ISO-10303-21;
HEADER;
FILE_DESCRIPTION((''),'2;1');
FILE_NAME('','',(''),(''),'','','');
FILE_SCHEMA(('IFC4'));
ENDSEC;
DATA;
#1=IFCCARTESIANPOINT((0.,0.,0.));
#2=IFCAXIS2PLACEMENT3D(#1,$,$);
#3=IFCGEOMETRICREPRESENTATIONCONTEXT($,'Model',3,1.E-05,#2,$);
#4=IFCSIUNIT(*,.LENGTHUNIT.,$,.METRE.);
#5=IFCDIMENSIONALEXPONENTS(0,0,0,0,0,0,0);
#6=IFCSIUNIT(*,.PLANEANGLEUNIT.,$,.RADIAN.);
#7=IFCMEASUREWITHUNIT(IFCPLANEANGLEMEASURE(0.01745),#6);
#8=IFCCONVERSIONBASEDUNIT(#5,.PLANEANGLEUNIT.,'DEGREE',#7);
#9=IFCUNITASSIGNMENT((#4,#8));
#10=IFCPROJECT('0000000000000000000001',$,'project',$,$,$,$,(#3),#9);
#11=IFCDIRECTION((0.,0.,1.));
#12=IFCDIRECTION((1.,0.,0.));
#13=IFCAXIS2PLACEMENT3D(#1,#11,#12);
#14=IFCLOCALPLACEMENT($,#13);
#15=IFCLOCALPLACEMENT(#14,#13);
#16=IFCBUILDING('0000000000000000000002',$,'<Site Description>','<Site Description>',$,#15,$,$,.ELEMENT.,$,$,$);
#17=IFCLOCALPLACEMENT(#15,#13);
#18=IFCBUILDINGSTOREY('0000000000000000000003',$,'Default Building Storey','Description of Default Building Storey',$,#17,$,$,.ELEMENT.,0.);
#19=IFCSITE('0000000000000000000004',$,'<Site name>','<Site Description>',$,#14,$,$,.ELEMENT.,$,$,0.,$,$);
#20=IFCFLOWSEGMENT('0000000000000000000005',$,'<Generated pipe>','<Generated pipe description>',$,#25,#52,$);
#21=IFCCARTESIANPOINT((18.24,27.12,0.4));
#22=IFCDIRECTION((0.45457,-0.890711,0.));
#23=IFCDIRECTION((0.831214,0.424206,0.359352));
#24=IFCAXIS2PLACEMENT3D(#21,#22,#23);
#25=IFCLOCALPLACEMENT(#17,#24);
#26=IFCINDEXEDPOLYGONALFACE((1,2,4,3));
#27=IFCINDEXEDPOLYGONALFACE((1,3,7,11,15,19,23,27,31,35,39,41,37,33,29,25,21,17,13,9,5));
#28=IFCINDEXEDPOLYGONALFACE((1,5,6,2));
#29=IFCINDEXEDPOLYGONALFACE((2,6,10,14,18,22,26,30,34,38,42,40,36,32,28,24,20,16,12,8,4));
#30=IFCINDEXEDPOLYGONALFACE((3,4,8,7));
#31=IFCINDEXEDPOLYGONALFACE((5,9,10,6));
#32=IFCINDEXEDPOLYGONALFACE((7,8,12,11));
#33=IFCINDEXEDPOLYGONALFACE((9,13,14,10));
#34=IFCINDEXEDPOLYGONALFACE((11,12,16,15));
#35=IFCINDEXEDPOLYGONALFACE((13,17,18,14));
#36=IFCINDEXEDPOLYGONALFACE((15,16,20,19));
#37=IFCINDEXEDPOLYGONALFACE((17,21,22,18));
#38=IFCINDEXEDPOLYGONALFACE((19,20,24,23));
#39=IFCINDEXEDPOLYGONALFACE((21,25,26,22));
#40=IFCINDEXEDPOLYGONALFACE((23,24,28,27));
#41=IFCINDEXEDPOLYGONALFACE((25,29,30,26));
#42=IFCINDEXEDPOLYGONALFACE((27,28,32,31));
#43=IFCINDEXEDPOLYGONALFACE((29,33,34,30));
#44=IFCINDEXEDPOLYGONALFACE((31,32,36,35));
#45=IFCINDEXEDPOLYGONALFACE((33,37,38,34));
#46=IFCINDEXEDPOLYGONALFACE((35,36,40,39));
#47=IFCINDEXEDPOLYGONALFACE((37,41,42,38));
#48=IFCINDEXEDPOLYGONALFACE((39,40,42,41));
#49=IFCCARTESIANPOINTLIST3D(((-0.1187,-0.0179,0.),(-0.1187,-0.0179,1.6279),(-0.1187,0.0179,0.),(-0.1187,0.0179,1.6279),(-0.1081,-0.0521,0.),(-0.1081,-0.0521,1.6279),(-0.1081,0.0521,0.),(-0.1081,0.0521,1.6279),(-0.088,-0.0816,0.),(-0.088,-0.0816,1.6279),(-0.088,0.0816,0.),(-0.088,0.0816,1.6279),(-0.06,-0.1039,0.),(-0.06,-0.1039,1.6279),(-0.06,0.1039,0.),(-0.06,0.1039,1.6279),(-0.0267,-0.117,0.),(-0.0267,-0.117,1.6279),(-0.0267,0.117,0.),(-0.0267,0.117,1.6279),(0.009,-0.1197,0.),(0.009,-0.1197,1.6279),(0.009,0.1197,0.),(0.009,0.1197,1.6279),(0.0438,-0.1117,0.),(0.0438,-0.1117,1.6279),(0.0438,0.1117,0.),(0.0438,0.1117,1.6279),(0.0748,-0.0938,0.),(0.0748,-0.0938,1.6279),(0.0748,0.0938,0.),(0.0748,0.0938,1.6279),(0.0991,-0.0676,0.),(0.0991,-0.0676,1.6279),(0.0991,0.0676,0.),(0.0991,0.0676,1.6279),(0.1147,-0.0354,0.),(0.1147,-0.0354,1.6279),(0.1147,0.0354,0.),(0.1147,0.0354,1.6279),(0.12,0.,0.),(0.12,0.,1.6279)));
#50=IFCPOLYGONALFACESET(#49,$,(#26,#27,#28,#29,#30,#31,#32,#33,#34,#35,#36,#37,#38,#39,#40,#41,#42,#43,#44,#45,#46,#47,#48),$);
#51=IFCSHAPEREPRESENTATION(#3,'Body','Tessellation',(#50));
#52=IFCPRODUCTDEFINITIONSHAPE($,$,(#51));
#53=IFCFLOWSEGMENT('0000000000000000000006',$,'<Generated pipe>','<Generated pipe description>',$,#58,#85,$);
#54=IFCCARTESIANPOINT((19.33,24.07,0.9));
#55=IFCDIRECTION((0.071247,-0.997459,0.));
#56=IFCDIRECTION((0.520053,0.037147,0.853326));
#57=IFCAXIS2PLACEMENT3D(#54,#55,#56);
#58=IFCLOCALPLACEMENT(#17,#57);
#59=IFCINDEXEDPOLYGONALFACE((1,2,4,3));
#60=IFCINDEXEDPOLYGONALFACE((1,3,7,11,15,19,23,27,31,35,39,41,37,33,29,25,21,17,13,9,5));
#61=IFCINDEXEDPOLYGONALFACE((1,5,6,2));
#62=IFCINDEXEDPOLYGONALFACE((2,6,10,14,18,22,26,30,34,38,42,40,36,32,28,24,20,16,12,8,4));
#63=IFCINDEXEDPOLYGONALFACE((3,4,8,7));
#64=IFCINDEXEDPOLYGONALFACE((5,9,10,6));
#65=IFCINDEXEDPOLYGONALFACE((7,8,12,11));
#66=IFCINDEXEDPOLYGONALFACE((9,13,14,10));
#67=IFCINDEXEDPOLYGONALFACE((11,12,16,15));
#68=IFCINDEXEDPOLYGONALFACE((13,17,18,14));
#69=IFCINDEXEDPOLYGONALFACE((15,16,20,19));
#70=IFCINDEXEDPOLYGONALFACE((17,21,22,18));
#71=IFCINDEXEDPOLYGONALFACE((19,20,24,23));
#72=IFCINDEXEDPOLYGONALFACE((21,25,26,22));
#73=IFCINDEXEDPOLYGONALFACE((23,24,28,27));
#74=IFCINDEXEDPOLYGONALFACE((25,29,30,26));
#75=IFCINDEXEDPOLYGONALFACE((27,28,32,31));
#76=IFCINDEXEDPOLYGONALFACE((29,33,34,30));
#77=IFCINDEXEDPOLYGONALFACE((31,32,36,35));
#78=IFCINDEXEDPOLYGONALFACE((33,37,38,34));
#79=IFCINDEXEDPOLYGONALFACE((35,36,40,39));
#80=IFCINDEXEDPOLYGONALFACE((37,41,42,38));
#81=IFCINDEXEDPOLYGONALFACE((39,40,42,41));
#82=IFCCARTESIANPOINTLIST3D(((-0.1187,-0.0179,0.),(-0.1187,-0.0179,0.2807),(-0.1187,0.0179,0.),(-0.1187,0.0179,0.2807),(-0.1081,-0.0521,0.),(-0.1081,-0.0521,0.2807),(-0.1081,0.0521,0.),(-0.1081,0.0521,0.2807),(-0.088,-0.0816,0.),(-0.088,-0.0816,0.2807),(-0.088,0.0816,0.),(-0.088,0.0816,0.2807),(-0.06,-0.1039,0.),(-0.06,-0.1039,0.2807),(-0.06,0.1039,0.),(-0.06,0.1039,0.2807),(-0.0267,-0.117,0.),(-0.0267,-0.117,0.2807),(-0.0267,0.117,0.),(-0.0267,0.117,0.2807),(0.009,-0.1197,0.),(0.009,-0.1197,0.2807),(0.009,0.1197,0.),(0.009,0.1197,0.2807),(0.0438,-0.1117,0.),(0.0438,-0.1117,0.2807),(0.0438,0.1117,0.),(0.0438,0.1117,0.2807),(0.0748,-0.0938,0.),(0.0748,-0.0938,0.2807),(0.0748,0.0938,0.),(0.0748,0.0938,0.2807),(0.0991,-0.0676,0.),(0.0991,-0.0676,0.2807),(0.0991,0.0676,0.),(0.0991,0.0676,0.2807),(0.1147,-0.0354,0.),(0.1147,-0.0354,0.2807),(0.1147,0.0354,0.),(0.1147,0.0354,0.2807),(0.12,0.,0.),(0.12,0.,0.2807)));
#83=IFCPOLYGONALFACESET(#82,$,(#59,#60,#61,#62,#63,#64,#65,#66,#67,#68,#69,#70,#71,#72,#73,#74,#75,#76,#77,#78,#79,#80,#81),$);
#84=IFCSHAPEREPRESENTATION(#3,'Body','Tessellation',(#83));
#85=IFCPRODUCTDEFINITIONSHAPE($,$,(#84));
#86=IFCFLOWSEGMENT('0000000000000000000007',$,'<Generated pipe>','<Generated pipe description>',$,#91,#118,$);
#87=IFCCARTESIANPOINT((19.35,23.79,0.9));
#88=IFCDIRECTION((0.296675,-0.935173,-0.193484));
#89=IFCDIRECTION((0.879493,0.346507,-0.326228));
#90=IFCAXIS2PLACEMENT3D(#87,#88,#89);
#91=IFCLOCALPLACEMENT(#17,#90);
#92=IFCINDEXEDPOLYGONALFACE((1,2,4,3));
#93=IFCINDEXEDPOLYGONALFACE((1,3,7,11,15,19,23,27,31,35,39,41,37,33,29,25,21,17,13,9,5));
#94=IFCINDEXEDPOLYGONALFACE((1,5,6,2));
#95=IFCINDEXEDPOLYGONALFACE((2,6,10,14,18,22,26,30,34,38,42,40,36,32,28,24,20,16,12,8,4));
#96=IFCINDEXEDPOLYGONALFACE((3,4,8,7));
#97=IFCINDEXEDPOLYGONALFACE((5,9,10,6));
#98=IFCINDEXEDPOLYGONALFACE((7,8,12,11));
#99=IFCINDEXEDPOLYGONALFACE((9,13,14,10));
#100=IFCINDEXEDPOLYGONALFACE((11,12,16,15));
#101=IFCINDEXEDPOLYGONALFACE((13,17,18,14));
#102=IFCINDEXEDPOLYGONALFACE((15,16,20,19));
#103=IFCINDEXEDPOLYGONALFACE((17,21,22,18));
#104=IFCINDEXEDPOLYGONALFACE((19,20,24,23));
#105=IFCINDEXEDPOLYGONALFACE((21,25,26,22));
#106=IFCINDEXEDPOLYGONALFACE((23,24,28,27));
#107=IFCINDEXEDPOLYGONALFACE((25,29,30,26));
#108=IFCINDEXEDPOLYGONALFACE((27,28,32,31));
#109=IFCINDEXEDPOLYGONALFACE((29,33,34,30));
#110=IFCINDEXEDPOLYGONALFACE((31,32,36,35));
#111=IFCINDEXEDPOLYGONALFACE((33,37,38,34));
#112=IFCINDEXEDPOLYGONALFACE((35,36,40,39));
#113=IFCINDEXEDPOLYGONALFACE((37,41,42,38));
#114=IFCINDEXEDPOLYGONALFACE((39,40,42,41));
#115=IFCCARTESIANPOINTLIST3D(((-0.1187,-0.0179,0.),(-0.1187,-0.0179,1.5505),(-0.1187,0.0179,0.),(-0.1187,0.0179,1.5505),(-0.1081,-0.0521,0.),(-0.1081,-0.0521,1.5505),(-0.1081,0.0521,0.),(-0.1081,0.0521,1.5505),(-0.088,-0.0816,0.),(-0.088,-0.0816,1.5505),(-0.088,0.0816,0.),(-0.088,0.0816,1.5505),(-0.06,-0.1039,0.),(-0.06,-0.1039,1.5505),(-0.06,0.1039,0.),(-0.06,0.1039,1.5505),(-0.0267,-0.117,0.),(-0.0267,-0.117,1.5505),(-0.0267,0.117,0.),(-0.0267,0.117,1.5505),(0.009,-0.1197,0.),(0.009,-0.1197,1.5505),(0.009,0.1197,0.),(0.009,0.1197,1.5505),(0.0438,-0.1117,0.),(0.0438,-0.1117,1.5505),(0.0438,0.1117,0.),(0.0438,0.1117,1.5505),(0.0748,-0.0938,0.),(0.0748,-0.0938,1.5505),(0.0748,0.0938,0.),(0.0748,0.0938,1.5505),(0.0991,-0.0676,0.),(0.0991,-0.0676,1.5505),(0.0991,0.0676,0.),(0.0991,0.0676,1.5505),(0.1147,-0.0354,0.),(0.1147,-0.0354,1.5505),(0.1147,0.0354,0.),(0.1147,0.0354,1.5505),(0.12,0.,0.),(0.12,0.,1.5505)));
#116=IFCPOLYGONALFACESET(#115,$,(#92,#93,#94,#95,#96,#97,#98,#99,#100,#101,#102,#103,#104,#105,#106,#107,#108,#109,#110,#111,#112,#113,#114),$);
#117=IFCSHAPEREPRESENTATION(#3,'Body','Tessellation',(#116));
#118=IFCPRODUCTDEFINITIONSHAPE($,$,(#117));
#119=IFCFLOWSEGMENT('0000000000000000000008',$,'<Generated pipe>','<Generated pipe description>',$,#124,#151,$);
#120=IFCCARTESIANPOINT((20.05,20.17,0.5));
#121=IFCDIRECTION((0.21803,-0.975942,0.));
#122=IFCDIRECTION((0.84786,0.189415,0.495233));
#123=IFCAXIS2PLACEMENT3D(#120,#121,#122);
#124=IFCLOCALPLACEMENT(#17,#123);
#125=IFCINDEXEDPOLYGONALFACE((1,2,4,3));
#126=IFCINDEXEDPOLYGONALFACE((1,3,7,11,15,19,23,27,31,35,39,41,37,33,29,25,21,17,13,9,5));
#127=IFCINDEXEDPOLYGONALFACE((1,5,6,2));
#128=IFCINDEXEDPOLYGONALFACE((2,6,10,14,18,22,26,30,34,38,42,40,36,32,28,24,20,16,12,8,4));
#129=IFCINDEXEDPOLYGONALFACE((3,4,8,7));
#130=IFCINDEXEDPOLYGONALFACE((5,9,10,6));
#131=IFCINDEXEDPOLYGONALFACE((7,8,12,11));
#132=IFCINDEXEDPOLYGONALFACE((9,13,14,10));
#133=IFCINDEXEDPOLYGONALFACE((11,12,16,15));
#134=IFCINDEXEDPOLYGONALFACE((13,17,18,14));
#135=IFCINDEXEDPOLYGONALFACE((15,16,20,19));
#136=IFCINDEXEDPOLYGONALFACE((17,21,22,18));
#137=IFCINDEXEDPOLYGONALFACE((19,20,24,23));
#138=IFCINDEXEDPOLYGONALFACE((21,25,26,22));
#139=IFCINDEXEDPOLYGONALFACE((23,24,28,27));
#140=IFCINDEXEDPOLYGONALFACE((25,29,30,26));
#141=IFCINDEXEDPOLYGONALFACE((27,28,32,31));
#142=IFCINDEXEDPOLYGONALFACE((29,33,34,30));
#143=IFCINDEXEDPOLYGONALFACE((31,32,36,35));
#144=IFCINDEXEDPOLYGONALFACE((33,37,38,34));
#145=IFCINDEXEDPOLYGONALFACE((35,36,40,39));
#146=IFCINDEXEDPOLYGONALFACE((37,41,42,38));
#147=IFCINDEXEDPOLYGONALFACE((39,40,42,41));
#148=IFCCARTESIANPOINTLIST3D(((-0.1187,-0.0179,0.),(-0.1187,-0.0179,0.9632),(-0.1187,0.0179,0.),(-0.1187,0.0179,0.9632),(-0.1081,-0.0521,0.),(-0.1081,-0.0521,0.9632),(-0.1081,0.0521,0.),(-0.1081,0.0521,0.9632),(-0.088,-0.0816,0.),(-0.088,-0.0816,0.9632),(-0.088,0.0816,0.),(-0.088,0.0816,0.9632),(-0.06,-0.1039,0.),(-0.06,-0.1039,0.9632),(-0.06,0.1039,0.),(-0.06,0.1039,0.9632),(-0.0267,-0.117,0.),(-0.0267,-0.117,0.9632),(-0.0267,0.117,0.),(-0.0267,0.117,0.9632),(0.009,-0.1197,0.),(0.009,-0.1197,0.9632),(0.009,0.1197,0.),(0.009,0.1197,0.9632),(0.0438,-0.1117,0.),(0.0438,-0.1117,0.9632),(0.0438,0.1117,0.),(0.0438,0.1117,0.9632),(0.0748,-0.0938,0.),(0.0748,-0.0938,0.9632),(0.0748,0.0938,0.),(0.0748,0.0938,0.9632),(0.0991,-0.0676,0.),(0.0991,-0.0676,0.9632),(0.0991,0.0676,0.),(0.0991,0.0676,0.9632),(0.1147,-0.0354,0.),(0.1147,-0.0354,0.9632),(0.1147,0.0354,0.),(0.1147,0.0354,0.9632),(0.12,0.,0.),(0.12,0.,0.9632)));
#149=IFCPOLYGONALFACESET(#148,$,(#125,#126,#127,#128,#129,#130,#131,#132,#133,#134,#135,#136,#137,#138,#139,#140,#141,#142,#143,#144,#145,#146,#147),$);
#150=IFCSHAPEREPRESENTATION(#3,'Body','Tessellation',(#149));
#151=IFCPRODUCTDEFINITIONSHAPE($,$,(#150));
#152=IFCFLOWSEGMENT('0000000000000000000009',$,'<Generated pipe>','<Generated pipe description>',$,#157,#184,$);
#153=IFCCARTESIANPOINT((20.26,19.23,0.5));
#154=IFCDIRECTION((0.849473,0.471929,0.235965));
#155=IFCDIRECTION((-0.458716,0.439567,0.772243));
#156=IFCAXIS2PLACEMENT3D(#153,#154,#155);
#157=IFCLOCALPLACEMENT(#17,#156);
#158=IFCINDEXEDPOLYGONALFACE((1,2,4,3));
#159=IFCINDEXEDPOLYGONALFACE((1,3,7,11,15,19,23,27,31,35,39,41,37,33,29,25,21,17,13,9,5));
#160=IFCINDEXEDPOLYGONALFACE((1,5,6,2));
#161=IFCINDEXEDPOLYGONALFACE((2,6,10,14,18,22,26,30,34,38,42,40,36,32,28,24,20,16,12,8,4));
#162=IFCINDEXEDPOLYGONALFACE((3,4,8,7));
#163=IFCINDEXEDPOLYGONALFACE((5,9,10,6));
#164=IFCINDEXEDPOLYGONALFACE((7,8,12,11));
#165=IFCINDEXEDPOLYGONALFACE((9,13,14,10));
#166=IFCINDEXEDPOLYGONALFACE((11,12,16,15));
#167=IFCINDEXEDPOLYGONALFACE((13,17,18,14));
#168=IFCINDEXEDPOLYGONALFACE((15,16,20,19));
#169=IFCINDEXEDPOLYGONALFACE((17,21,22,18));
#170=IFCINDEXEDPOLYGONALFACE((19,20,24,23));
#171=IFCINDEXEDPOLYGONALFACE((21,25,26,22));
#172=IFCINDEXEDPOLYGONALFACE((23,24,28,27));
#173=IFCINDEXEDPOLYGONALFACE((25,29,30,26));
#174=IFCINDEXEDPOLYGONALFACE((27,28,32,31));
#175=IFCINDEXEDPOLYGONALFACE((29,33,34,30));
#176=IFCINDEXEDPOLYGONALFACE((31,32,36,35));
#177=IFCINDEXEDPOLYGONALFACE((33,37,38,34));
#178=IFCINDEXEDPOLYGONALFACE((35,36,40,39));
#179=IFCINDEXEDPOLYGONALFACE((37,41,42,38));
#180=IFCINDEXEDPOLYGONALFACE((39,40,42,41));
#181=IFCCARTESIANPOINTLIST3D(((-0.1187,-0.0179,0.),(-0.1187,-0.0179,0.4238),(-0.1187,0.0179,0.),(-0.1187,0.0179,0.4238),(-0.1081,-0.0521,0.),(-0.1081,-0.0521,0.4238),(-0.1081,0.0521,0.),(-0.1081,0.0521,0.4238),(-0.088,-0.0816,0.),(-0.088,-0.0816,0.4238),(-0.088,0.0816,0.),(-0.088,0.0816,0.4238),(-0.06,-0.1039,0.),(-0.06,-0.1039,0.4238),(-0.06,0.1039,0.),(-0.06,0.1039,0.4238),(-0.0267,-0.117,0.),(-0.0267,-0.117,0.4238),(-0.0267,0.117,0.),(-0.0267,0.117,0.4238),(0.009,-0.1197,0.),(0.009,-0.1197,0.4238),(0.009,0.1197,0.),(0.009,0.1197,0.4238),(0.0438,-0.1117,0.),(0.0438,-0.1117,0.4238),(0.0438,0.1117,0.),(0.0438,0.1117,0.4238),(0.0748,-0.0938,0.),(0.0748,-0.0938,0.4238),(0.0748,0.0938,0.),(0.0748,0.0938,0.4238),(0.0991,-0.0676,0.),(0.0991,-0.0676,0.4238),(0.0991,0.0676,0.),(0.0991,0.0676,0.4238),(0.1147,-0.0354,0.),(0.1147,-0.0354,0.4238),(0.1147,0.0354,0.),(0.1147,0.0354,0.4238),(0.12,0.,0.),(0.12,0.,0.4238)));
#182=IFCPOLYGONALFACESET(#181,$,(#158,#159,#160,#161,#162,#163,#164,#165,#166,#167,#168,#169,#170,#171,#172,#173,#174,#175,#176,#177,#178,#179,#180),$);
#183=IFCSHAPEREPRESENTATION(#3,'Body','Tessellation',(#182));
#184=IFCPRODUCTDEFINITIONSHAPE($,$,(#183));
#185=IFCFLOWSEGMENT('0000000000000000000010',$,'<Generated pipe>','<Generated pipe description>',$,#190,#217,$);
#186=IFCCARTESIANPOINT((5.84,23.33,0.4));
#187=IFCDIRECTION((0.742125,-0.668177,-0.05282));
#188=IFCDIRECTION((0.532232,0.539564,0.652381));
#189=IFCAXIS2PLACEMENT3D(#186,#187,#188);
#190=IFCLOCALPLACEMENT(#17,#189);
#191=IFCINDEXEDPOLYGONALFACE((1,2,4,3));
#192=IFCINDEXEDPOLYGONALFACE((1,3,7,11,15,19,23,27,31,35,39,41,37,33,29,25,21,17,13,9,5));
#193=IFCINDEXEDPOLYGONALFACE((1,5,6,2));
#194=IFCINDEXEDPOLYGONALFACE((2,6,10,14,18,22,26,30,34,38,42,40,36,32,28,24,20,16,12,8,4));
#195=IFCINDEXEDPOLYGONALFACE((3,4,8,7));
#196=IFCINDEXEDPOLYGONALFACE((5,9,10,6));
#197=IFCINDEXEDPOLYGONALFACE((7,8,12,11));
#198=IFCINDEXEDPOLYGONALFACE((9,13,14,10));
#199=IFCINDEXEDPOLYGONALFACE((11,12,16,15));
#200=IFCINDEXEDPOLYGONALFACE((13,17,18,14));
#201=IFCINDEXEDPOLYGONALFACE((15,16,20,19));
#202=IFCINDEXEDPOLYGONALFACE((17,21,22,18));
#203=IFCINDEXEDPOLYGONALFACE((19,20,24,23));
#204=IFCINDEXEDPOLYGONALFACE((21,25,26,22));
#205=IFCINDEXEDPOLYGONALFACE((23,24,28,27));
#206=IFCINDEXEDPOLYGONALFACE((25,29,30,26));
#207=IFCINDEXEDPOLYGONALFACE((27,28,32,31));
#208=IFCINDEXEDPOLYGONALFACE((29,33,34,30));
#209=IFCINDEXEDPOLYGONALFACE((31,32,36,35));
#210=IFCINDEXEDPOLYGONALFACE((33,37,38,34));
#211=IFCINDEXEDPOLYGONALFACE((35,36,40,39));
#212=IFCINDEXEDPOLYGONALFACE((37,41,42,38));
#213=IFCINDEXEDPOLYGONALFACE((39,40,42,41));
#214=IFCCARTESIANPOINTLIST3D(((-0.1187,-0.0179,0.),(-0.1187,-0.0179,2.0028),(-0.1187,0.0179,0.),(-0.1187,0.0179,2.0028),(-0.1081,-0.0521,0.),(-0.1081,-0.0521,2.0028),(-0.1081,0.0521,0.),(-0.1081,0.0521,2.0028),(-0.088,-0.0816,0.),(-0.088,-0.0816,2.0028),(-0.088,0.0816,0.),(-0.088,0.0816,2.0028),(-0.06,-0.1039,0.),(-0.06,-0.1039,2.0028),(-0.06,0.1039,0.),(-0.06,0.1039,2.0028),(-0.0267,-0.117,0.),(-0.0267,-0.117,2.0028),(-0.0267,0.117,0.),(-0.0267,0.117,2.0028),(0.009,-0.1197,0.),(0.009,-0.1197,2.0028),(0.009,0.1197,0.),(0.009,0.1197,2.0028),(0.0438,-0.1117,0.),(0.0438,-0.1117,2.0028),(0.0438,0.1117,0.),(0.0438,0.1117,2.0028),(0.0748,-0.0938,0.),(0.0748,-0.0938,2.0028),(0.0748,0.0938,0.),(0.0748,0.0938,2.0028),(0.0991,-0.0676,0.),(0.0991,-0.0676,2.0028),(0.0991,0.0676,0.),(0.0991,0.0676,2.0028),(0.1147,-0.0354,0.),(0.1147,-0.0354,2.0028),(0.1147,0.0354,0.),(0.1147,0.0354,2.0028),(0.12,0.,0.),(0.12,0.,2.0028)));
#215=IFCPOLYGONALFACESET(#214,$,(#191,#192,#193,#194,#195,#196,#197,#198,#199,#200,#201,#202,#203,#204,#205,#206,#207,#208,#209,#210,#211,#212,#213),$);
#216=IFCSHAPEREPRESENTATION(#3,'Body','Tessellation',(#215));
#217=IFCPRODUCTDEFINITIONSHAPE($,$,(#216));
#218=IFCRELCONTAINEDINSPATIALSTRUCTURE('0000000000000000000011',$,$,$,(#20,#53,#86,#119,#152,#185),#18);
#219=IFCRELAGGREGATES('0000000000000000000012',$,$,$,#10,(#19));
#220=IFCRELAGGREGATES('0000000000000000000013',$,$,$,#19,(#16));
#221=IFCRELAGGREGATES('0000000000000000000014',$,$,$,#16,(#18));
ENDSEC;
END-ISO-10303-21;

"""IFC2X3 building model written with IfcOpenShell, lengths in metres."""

from ifc_helpers import new_model, entity, si_unit, converted_unit, frame, origin, origin_with_axes, origin_2d_with_axis, place, context, project, spatial, circle, extrude, element, save


model = new_model("IFC2X3")

# Units and contexts
model_context = context("Model", 3, precision=1e-05, world=origin())
ifc_project = project(units=[si_unit("LENGTHUNIT", "METRE"), converted_unit("PLANEANGLEUNIT", "DEGREE", entity("IfcPlaneAngleMeasure", 0.01745), si_unit("PLANEANGLEUNIT", "RADIAN"), dimensions=[0, 0, 0, 0, 0, 0, 0])], contexts=[model_context])

# Site, building, storey
site_placement = place(None, origin_with_axes())
site = spatial("IfcSite", under=ifc_project, at=site_placement, Name="<Site name>", Description="<Site Description>", CompositionType="ELEMENT", RefElevation=0.0)
building_placement = place(site_placement, origin_with_axes())
building = spatial("IfcBuilding", under=site, at=building_placement, Name="<Site Description>", Description="<Site Description>", CompositionType="ELEMENT")
storey_placement = place(building_placement, origin_with_axes())
storey = spatial("IfcBuildingStorey", under=building, at=storey_placement, Name="Default Building Storey", Description="Description of Default Building Storey", CompositionType="ELEMENT", Elevation=0.0)

# Flow segments
flow_segment_1_placement = place(storey_placement, frame((18.24, 27.12, 0.4), z_axis=(0.45457, -0.890711, 0.0), x_axis=(0.831214, 0.424206, 0.359352)))
element("IfcFlowSegment", 1, at=flow_segment_1_placement, inside=storey, Name="<Generated pipe>", Description="<Generated pipe description>", context=model_context, shape_type="SweptSolid", body=[
    extrude(circle(Radius=0.12, at=origin_2d_with_axis()), origin_with_axes(), (0.0, 0.0, 1.0), 1.6279),
])
flow_segment_2_placement = place(storey_placement, frame((19.33, 24.07, 0.9), z_axis=(0.071247, -0.997459, 0.0), x_axis=(0.520053, 0.037147, 0.853326)))
element("IfcFlowSegment", 2, at=flow_segment_2_placement, inside=storey, Name="<Generated pipe>", Description="<Generated pipe description>", context=model_context, shape_type="SweptSolid", body=[
    extrude(circle(Radius=0.12, at=origin_2d_with_axis()), origin_with_axes(), (0.0, 0.0, 1.0), 0.2807),
])
flow_segment_3_placement = place(storey_placement, frame((19.35, 23.79, 0.9), z_axis=(0.296675, -0.935173, -0.193484), x_axis=(0.879493, 0.346507, -0.326228)))
element("IfcFlowSegment", 3, at=flow_segment_3_placement, inside=storey, Name="<Generated pipe>", Description="<Generated pipe description>", context=model_context, shape_type="SweptSolid", body=[
    extrude(circle(Radius=0.12, at=origin_2d_with_axis()), origin_with_axes(), (0.0, 0.0, 1.0), 1.5505),
])
flow_segment_4_placement = place(storey_placement, frame((20.05, 20.17, 0.5), z_axis=(0.21803, -0.975942, 0.0), x_axis=(0.84786, 0.189415, 0.495233)))
element("IfcFlowSegment", 4, at=flow_segment_4_placement, inside=storey, Name="<Generated pipe>", Description="<Generated pipe description>", context=model_context, shape_type="SweptSolid", body=[
    extrude(circle(Radius=0.12, at=origin_2d_with_axis()), origin_with_axes(), (0.0, 0.0, 1.0), 0.9632),
])
flow_segment_5_placement = place(storey_placement, frame((20.26, 19.23, 0.5), z_axis=(0.849473, 0.471929, 0.235965), x_axis=(-0.458716, 0.439567, 0.772243)))
element("IfcFlowSegment", 5, at=flow_segment_5_placement, inside=storey, Name="<Generated pipe>", Description="<Generated pipe description>", context=model_context, shape_type="SweptSolid", body=[
    extrude(circle(Radius=0.12, at=origin_2d_with_axis()), origin_with_axes(), (0.0, 0.0, 1.0), 0.4238),
])
flow_segment_6_placement = place(storey_placement, frame((5.84, 23.33, 0.4), z_axis=(0.742125, -0.668177, -0.05282), x_axis=(0.532232, 0.539564, 0.652381)))
element("IfcFlowSegment", 6, at=flow_segment_6_placement, inside=storey, Name="<Generated pipe>", Description="<Generated pipe description>", context=model_context, shape_type="SweptSolid", body=[
    extrude(circle(Radius=0.12, at=origin_2d_with_axis()), origin_with_axes(), (0.0, 0.0, 1.0), 2.0028),
])

save(model, "model.ifc")
